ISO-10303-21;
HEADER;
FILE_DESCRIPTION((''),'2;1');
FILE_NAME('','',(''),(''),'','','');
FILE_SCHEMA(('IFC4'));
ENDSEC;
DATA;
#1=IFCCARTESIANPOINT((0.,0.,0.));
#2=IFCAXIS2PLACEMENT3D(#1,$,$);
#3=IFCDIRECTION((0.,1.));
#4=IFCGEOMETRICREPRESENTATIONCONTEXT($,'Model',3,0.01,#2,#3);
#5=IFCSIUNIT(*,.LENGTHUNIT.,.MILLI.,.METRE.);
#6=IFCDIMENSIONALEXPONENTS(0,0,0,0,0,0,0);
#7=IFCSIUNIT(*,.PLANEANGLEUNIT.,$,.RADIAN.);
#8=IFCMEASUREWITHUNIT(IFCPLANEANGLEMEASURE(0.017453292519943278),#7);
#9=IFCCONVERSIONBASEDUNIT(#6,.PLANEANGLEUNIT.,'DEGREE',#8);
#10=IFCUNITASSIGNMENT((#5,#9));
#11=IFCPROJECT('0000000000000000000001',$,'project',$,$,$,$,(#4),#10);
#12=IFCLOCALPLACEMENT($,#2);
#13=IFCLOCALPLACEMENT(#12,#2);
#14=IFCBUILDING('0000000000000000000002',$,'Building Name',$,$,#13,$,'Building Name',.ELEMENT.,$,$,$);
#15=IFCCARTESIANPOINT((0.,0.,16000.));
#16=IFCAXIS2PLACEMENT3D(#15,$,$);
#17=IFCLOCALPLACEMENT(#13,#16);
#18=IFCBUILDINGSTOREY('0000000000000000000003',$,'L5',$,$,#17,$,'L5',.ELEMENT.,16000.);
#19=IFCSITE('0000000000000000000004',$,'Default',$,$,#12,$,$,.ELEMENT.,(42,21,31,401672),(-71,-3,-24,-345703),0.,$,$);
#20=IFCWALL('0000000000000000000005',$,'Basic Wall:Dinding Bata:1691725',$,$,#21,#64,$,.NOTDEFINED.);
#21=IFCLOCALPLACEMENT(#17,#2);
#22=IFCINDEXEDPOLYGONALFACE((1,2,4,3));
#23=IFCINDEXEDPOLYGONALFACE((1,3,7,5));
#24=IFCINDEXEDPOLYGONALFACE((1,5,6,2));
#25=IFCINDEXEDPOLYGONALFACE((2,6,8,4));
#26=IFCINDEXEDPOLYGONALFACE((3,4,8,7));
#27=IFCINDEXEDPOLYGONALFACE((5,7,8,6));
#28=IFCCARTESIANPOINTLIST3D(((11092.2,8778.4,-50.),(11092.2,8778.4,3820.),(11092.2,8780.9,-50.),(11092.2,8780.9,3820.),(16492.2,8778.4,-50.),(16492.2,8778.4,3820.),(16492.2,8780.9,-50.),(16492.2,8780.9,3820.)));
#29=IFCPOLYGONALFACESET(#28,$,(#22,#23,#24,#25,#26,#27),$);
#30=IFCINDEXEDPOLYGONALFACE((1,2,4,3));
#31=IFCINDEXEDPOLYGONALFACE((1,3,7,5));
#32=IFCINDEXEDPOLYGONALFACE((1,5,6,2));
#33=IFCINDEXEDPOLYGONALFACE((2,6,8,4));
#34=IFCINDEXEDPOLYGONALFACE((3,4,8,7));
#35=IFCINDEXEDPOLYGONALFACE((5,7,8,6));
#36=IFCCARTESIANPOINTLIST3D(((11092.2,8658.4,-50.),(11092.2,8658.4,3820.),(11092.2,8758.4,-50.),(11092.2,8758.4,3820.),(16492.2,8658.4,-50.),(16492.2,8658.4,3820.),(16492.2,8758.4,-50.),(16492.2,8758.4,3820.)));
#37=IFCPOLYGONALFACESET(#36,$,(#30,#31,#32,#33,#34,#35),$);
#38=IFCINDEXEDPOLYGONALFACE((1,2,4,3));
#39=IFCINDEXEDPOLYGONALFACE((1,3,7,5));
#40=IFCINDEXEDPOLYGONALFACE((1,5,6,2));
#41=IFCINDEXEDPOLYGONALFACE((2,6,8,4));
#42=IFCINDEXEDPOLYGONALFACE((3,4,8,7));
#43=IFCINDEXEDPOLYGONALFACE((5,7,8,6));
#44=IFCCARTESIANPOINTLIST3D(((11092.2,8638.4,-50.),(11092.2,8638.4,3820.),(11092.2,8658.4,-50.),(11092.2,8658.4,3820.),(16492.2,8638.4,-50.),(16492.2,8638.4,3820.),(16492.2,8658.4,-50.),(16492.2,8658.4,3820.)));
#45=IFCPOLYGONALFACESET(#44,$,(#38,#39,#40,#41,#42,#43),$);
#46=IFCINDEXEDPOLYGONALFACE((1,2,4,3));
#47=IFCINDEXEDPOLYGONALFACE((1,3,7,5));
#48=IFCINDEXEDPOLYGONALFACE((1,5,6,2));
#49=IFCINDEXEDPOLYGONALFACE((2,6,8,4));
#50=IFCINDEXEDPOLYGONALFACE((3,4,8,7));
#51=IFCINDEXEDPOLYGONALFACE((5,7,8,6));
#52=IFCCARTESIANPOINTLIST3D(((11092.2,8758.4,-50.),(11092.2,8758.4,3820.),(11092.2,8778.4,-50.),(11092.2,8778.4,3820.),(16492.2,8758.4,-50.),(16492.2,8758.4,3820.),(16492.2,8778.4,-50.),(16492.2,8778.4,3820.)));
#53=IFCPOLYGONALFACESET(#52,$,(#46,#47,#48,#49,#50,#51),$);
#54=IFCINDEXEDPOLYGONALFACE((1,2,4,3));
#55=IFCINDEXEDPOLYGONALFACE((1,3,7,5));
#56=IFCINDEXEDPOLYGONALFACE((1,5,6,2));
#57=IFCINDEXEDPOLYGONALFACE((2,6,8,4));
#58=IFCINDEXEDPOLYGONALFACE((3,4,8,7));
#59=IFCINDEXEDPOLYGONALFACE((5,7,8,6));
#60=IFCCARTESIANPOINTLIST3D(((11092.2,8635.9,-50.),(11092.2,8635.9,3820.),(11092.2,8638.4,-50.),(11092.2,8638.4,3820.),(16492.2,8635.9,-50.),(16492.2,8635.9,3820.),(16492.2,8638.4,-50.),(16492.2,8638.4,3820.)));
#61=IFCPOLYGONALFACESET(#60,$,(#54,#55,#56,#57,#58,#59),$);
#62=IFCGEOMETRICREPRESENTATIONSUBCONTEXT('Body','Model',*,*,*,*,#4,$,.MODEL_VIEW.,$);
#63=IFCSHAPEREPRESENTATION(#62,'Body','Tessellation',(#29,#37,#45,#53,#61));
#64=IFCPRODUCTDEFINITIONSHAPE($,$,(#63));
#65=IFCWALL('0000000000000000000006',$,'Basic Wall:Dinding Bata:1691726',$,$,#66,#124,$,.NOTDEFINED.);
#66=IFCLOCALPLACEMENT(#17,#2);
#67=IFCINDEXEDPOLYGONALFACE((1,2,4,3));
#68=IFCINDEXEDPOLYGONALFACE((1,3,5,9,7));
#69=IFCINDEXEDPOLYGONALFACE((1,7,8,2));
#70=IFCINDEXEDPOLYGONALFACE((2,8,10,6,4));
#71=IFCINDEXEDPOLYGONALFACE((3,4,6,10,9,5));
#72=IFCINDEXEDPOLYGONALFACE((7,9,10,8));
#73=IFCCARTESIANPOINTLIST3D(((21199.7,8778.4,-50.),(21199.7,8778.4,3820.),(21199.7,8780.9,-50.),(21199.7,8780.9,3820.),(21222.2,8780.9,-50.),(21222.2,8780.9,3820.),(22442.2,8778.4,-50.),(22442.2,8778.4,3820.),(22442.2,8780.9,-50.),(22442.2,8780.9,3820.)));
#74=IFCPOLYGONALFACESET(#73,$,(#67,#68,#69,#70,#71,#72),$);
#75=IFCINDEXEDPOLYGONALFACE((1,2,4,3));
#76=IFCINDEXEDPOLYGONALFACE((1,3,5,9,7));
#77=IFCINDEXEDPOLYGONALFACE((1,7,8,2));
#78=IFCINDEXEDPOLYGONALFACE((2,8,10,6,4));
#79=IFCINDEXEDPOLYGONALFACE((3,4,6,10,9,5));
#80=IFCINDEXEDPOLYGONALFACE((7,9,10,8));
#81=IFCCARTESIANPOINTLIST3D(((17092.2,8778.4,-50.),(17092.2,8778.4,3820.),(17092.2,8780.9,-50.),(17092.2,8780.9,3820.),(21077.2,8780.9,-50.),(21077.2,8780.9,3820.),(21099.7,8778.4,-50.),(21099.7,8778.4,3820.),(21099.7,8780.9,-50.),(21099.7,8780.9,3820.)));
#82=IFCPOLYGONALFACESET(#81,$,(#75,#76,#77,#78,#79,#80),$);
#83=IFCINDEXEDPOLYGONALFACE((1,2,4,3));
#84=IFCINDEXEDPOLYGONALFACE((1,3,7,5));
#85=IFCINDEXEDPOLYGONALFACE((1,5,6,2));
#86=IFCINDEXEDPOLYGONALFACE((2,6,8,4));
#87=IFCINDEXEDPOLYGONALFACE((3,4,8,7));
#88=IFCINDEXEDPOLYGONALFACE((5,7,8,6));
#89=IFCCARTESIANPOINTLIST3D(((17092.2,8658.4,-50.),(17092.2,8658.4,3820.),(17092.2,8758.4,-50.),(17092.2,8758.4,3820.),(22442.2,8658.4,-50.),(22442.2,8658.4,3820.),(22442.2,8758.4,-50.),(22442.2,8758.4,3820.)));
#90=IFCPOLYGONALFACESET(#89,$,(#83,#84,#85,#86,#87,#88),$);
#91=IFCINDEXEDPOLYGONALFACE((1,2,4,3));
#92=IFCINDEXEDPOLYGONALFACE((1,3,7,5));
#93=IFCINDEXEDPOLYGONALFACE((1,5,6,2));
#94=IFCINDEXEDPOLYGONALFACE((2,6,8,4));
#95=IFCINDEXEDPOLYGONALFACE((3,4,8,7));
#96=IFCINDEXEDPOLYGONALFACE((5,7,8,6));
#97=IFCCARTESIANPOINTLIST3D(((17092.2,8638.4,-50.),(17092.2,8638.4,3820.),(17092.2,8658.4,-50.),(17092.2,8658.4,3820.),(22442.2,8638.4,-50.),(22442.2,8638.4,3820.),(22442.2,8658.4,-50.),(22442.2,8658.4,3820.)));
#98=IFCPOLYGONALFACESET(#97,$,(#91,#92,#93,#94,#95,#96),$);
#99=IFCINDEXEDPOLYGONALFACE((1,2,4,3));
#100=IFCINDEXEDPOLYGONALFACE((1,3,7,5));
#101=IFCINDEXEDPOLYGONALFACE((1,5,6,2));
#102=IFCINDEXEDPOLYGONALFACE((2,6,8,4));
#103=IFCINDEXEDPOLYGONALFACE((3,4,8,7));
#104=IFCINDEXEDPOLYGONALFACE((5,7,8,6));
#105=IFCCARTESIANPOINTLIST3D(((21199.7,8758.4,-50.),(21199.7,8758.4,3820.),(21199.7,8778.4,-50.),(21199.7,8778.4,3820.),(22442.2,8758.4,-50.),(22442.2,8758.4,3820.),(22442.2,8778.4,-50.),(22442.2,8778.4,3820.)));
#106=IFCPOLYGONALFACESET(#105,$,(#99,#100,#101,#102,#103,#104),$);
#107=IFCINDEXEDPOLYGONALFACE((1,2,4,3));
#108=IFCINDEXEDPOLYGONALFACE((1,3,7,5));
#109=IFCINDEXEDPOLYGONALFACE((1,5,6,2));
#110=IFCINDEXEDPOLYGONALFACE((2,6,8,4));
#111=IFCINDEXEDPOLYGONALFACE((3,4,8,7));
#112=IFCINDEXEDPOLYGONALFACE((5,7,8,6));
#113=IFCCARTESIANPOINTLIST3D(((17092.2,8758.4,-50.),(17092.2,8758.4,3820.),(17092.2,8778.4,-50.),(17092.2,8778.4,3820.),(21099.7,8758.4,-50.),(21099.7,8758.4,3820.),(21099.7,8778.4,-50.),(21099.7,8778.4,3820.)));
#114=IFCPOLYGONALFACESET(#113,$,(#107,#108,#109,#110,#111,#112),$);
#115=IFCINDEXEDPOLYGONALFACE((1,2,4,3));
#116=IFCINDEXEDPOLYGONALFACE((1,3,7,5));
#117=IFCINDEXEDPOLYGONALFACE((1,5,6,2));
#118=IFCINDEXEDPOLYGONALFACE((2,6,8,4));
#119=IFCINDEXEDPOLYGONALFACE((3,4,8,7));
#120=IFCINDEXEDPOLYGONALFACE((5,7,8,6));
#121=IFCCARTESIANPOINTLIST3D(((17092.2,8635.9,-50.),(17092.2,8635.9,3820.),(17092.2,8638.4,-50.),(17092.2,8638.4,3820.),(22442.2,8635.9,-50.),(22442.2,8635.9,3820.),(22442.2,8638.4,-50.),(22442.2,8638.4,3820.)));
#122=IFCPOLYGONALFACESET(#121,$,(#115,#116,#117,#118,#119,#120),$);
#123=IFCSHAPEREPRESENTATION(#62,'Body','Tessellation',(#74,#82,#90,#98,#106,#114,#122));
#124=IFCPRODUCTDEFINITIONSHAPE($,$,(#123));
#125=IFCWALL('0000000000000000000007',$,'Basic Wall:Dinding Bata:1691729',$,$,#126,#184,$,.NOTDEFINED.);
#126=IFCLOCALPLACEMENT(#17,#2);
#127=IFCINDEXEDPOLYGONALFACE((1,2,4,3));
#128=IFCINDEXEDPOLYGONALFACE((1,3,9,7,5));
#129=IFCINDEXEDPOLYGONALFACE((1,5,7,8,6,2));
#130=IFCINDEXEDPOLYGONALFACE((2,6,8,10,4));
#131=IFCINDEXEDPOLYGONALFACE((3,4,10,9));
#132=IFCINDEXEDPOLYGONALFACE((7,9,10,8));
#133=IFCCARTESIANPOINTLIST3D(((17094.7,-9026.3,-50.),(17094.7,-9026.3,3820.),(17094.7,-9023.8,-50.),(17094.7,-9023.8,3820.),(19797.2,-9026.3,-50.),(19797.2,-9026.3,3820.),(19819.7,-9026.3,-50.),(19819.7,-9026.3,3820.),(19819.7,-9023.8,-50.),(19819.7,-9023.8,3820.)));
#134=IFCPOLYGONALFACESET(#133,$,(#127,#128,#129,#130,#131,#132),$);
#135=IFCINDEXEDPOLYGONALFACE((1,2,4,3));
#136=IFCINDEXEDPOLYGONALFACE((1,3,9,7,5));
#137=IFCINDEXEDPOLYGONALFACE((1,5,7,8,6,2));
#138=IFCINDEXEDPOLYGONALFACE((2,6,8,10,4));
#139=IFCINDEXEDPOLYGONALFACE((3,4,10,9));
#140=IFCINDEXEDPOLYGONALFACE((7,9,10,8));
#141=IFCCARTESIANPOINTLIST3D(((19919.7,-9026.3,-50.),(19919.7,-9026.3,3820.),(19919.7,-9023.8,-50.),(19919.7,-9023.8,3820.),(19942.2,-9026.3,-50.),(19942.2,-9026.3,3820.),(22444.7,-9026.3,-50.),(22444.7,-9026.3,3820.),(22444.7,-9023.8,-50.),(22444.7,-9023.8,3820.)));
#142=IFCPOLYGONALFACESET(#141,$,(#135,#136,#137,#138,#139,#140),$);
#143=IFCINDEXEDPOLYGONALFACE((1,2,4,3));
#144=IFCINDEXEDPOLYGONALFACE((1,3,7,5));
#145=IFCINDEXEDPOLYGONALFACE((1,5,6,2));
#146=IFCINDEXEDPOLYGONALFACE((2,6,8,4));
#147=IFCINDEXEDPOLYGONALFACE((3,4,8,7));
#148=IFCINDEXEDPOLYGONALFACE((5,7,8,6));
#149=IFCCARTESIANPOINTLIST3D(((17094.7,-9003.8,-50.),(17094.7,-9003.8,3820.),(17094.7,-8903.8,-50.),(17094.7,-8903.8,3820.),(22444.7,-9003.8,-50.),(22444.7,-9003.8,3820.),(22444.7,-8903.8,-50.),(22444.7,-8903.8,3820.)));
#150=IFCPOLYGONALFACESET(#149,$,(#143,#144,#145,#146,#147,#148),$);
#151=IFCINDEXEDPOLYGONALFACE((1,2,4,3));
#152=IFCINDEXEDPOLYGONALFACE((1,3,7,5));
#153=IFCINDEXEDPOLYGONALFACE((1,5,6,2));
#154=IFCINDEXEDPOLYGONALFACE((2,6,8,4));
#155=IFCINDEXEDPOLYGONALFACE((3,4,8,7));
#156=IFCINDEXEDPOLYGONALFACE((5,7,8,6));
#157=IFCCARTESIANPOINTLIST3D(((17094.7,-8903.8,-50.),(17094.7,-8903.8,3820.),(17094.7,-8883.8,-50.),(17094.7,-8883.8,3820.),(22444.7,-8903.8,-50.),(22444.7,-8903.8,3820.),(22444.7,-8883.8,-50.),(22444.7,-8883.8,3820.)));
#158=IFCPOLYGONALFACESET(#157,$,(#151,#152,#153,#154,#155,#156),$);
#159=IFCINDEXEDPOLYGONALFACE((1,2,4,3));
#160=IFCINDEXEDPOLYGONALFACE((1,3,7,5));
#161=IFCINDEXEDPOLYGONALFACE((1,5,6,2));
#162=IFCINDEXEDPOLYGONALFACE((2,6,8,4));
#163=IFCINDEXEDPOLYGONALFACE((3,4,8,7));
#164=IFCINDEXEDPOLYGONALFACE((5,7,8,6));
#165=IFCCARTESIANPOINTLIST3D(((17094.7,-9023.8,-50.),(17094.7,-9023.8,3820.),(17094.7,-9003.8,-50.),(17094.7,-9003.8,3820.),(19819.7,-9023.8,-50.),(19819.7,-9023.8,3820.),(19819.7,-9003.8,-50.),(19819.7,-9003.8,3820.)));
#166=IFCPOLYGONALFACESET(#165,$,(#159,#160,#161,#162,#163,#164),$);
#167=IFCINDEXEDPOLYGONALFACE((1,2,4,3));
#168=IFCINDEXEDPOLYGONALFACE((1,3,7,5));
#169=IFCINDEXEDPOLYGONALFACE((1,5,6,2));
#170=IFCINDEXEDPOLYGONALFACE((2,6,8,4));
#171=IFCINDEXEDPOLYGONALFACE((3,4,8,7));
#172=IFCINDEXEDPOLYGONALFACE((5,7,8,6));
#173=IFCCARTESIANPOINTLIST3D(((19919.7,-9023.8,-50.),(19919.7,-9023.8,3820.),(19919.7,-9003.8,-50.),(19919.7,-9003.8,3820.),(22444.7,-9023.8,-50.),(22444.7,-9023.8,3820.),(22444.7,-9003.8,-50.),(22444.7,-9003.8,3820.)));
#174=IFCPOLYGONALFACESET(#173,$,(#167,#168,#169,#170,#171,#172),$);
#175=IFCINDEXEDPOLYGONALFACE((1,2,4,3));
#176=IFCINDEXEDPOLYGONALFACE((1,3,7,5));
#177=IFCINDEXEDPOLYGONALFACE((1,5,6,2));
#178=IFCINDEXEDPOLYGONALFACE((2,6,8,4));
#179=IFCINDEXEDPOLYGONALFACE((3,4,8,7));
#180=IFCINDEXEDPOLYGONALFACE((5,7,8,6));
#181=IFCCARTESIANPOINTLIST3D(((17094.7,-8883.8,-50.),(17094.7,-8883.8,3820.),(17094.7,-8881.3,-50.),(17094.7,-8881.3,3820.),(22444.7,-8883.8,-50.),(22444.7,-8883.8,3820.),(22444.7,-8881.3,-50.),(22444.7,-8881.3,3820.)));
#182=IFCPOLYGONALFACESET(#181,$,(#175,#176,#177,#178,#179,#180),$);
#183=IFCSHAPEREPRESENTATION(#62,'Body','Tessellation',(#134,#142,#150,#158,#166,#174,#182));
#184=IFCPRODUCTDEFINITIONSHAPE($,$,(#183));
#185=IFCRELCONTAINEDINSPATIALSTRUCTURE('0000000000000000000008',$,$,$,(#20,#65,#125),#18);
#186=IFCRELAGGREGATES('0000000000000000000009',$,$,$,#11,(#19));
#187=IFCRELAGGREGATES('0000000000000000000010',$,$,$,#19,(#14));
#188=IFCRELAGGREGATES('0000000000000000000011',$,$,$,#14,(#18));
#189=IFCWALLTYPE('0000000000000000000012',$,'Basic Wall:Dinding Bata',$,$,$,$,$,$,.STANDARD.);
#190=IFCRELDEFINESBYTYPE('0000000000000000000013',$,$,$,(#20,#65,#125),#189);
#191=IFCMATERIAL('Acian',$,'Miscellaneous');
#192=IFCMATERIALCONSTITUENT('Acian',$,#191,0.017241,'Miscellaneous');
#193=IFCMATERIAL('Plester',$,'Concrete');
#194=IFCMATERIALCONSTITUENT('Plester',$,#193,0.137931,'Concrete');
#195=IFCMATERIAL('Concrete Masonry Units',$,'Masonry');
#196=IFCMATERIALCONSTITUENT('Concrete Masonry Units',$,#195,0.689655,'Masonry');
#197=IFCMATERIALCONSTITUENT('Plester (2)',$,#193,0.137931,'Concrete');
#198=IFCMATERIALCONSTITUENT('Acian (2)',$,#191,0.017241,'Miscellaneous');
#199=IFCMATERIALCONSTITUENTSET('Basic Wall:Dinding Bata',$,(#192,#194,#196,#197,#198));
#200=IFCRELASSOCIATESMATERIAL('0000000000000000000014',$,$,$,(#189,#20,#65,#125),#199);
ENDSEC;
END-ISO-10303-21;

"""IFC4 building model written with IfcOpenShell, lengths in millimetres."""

from ifc_helpers import new_model, entity, si_unit, converted_unit, direction, frame, origin, place, context, subcontext, project, spatial, indexed_curve, outline, extrude, material, constituent, constituent_set, type_object, element, save


model = new_model("IFC4")

# Units and contexts
model_context = context("Model", 3, precision=0.01, world=origin(), true_north=direction((0.0, 1.0)))
body_context = subcontext(model_context, "Body", "Model", "MODEL_VIEW")
ifc_project = project(units=[si_unit("LENGTHUNIT", "METRE", prefix="MILLI"), converted_unit("PLANEANGLEUNIT", "DEGREE", entity("IfcPlaneAngleMeasure", 0.017453292519943278), si_unit("PLANEANGLEUNIT", "RADIAN"), dimensions=[0, 0, 0, 0, 0, 0, 0])], contexts=[model_context])

# Site, building, storey
site_placement = place(None, origin())
site = spatial("IfcSite", under=ifc_project, at=site_placement, Name="Default", CompositionType="ELEMENT", RefLatitude=(42, 21, 31, 401672), RefLongitude=(-71, -3, -24, -345703), RefElevation=0.0)
building_placement = place(site_placement, origin())
building = spatial("IfcBuilding", under=site, at=building_placement, Name="Building Name", LongName="Building Name", CompositionType="ELEMENT")
storey_placement = place(building_placement, frame((0.0, 0.0, 16000.0)))
storey = spatial("IfcBuildingStorey", under=building, at=storey_placement, Name="L5", LongName="L5", CompositionType="ELEMENT", Elevation=16000.0)

# Walls
ifc_material_1 = material(Name="Acian", Category="Miscellaneous")
ifc_constituent_1 = constituent(ifc_material_1, Name="Acian", Category="Miscellaneous", fraction=0.017241)
ifc_material_2 = material(Name="Plester", Category="Concrete")
ifc_constituent_2 = constituent(ifc_material_2, Name="Plester", Category="Concrete", fraction=0.137931)
ifc_material_3 = material(Name="Concrete Masonry Units", Category="Masonry")
ifc_constituent_3 = constituent(ifc_material_3, Name="Concrete Masonry Units", Category="Masonry", fraction=0.689655)
ifc_constituent_4 = constituent(ifc_material_2, Name="Plester (2)", Category="Concrete", fraction=0.137931)
ifc_constituent_5 = constituent(ifc_material_1, Name="Acian (2)", Category="Miscellaneous", fraction=0.017241)
ifc_constituent_set = constituent_set(constituents=[ifc_constituent_1, ifc_constituent_2, ifc_constituent_3, ifc_constituent_4, ifc_constituent_5], Name="Basic Wall:Dinding Bata")
wall_type = type_object("IfcWallType", Name="Basic Wall:Dinding Bata", PredefinedType="STANDARD", material=ifc_constituent_set)
wall_1_placement = place(storey_placement, frame((11092.2, 8708.4, -50.0)))
element("IfcWall", 1, at=wall_1_placement, inside=storey, type_object=wall_type, material=ifc_constituent_set, Name="Basic Wall:Dinding Bata:1691725", PredefinedType="NOTDEFINED", context=body_context, shape_type="SweptSolid", body=[
    extrude(outline(indexed_curve([(-1.3, -2700.0), (1.2, -2700.0), (1.3, 2700.0), (-1.2, 2700.0), (-1.3, -2700.0)], self_intersect=False)), frame((2700.0, 71.3, 0.0), z_axis=(0.0, 0.0, 1.0), x_axis=(0.0, -1.0, 0.0)), (0.0, 0.0, 1.0), 3870.0),
    extrude(outline(indexed_curve([(-2700.0, -50.0), (2700.0, -50.0), (2700.0, 50.0), (-2700.0, 50.0), (-2700.0, -50.0)], self_intersect=False)), frame((2700.0, 0.0, 0.0)), (0.0, 0.0, 1.0), 3870.0),
    extrude(outline(indexed_curve([(-2700.0, -10.0), (2700.0, -10.0), (2700.0, 10.0), (-2700.0, 10.0), (-2700.0, -10.0)], self_intersect=False)), frame((2700.0, -60.0, 0.0)), (0.0, 0.0, 1.0), 3870.0),
    extrude(outline(indexed_curve([(-2700.0, -10.0), (2700.0, -10.0), (2700.0, 10.0), (-2700.0, 10.0), (-2700.0, -10.0)], self_intersect=False)), frame((2700.0, 60.0, 0.0)), (0.0, 0.0, 1.0), 3870.0),
    extrude(outline(indexed_curve([(-1.3, -2700.0), (1.2, -2700.0), (1.3, 2700.0), (-1.2, 2700.0), (-1.3, -2700.0)], self_intersect=False)), frame((2700.0, -71.3, 0.0), z_axis=(0.0, 0.0, 1.0), x_axis=(0.0, 1.0, 0.0)), (0.0, 0.0, 1.0), 3870.0),
])
wall_2_placement = place(storey_placement, frame((17092.2, 8708.4, -50.0)))
element("IfcWall", 2, at=wall_2_placement, inside=storey, type_object=wall_type, material=ifc_constituent_set, Name="Basic Wall:Dinding Bata:1691726", PredefinedType="NOTDEFINED", context=body_context, shape_type="SweptSolid", body=[
    extrude(outline(indexed_curve([(479.0, -1.0), (501.5, -1.0), (501.5, 1.5), (-741.0, 1.5), (-741.0, -1.0), (479.0, -1.0)], self_intersect=False)), frame((4609.0, 71.5, 0.0), z_axis=(0.0, 0.0, 1.0), x_axis=(-1.0, 0.0, 0.0)), (0.0, 0.0, 1.0), 3870.0),
    extrude(outline(indexed_curve([(-2400.0, -1.5), (1607.5, -1.5), (1607.5, 1.0), (1585.0, 1.0), (-2400.0, 1.0), (-2400.0, -1.5)], self_intersect=False)), frame((2400.0, 71.5, 0.0)), (0.0, 0.0, 1.0), 3870.0),
    extrude(outline(indexed_curve([(-2675.0, -50.0), (2675.0, -50.0), (2675.0, 50.0), (-2675.0, 50.0), (-2675.0, -50.0)], self_intersect=False)), frame((2675.0, 0.0, 0.0)), (0.0, 0.0, 1.0), 3870.0),
    extrude(outline(indexed_curve([(-2675.0, -10.0), (2675.0, -10.0), (2675.0, 10.0), (-2675.0, 10.0), (-2675.0, -10.0)], self_intersect=False)), frame((2675.0, -60.0, 0.0)), (0.0, 0.0, 1.0), 3870.0),
    extrude(outline(indexed_curve([(-621.3, -10.0), (621.3, -10.0), (621.3, 10.0), (-621.3, 10.0), (-621.3, -10.0)], self_intersect=False)), frame((4728.7, 60.0, 0.0), z_axis=(0.0, 0.0, 1.0), x_axis=(-1.0, 0.0, 0.0)), (0.0, 0.0, 1.0), 3870.0),
    extrude(outline(indexed_curve([(-2003.7, -10.0), (2003.7, -10.0), (2003.7, 10.0), (-2003.7, 10.0), (-2003.7, -10.0)], self_intersect=False)), frame((2003.7, 60.0, 0.0)), (0.0, 0.0, 1.0), 3870.0),
    extrude(outline(indexed_curve([(-1.3, -2675.0), (1.2, -2675.0), (1.3, 2675.0), (-1.2, 2675.0), (-1.3, -2675.0)], self_intersect=False)), frame((2675.0, -71.3, 0.0), z_axis=(0.0, 0.0, 1.0), x_axis=(0.0, 1.0, 0.0)), (0.0, 0.0, 1.0), 3870.0),
])
wall_3_placement = place(storey_placement, frame((22444.7, -8953.8, -50.0), z_axis=(0.0, 0.0, 1.0), x_axis=(-1.0, 0.0, 0.0)))
element("IfcWall", 3, at=wall_3_placement, inside=storey, type_object=wall_type, material=ifc_constituent_set, Name="Basic Wall:Dinding Bata:1691729", PredefinedType="NOTDEFINED", context=body_context, shape_type="SweptSolid", body=[
    extrude(outline(indexed_curve([(1072.0, -1.0), (1094.5, -1.0), (1094.5, 1.5), (-1630.5, 1.5), (-1630.5, -1.0), (1072.0, -1.0)], self_intersect=False)), frame((3719.5, 71.5, 0.0), z_axis=(0.0, 0.0, 1.0), x_axis=(-1.0, 0.0, 0.0)), (0.0, 0.0, 1.0), 3870.0),
    extrude(outline(indexed_curve([(-1510.5, -1.5), (1014.5, -1.5), (1014.5, 1.0), (992.0, 1.0), (-1510.5, 1.0), (-1510.5, -1.5)], self_intersect=False)), frame((1510.5, 71.5, 0.0)), (0.0, 0.0, 1.0), 3870.0),
    extrude(outline(indexed_curve([(-2675.0, -50.0), (2675.0, -50.0), (2675.0, 50.0), (-2675.0, 50.0), (-2675.0, -50.0)], self_intersect=False)), frame((2675.0, 0.0, 0.0)), (0.0, 0.0, 1.0), 3870.0),
    extrude(outline(indexed_curve([(-2675.0, -10.0), (2675.0, -10.0), (2675.0, 10.0), (-2675.0, 10.0), (-2675.0, -10.0)], self_intersect=False)), frame((2675.0, -60.0, 0.0)), (0.0, 0.0, 1.0), 3870.0),
    extrude(outline(indexed_curve([(-1362.5, -10.0), (1362.5, -10.0), (1362.5, 10.0), (-1362.5, 10.0), (-1362.5, -10.0)], self_intersect=False)), frame((3987.5, 60.0, 0.0), z_axis=(0.0, 0.0, 1.0), x_axis=(-1.0, 0.0, 0.0)), (0.0, 0.0, 1.0), 3870.0),
    extrude(outline(indexed_curve([(-1262.5, -10.0), (1262.5, -10.0), (1262.5, 10.0), (-1262.5, 10.0), (-1262.5, -10.0)], self_intersect=False)), frame((1262.5, 60.0, 0.0)), (0.0, 0.0, 1.0), 3870.0),
    extrude(outline(indexed_curve([(-1.3, -2675.0), (1.2, -2675.0), (1.3, 2675.0), (-1.2, 2675.0), (-1.3, -2675.0)], self_intersect=False)), frame((2675.0, -71.3, 0.0), z_axis=(0.0, 0.0, 1.0), x_axis=(0.0, 1.0, 0.0)), (0.0, 0.0, 1.0), 3870.0),
])

save(model, "model.ifc")
